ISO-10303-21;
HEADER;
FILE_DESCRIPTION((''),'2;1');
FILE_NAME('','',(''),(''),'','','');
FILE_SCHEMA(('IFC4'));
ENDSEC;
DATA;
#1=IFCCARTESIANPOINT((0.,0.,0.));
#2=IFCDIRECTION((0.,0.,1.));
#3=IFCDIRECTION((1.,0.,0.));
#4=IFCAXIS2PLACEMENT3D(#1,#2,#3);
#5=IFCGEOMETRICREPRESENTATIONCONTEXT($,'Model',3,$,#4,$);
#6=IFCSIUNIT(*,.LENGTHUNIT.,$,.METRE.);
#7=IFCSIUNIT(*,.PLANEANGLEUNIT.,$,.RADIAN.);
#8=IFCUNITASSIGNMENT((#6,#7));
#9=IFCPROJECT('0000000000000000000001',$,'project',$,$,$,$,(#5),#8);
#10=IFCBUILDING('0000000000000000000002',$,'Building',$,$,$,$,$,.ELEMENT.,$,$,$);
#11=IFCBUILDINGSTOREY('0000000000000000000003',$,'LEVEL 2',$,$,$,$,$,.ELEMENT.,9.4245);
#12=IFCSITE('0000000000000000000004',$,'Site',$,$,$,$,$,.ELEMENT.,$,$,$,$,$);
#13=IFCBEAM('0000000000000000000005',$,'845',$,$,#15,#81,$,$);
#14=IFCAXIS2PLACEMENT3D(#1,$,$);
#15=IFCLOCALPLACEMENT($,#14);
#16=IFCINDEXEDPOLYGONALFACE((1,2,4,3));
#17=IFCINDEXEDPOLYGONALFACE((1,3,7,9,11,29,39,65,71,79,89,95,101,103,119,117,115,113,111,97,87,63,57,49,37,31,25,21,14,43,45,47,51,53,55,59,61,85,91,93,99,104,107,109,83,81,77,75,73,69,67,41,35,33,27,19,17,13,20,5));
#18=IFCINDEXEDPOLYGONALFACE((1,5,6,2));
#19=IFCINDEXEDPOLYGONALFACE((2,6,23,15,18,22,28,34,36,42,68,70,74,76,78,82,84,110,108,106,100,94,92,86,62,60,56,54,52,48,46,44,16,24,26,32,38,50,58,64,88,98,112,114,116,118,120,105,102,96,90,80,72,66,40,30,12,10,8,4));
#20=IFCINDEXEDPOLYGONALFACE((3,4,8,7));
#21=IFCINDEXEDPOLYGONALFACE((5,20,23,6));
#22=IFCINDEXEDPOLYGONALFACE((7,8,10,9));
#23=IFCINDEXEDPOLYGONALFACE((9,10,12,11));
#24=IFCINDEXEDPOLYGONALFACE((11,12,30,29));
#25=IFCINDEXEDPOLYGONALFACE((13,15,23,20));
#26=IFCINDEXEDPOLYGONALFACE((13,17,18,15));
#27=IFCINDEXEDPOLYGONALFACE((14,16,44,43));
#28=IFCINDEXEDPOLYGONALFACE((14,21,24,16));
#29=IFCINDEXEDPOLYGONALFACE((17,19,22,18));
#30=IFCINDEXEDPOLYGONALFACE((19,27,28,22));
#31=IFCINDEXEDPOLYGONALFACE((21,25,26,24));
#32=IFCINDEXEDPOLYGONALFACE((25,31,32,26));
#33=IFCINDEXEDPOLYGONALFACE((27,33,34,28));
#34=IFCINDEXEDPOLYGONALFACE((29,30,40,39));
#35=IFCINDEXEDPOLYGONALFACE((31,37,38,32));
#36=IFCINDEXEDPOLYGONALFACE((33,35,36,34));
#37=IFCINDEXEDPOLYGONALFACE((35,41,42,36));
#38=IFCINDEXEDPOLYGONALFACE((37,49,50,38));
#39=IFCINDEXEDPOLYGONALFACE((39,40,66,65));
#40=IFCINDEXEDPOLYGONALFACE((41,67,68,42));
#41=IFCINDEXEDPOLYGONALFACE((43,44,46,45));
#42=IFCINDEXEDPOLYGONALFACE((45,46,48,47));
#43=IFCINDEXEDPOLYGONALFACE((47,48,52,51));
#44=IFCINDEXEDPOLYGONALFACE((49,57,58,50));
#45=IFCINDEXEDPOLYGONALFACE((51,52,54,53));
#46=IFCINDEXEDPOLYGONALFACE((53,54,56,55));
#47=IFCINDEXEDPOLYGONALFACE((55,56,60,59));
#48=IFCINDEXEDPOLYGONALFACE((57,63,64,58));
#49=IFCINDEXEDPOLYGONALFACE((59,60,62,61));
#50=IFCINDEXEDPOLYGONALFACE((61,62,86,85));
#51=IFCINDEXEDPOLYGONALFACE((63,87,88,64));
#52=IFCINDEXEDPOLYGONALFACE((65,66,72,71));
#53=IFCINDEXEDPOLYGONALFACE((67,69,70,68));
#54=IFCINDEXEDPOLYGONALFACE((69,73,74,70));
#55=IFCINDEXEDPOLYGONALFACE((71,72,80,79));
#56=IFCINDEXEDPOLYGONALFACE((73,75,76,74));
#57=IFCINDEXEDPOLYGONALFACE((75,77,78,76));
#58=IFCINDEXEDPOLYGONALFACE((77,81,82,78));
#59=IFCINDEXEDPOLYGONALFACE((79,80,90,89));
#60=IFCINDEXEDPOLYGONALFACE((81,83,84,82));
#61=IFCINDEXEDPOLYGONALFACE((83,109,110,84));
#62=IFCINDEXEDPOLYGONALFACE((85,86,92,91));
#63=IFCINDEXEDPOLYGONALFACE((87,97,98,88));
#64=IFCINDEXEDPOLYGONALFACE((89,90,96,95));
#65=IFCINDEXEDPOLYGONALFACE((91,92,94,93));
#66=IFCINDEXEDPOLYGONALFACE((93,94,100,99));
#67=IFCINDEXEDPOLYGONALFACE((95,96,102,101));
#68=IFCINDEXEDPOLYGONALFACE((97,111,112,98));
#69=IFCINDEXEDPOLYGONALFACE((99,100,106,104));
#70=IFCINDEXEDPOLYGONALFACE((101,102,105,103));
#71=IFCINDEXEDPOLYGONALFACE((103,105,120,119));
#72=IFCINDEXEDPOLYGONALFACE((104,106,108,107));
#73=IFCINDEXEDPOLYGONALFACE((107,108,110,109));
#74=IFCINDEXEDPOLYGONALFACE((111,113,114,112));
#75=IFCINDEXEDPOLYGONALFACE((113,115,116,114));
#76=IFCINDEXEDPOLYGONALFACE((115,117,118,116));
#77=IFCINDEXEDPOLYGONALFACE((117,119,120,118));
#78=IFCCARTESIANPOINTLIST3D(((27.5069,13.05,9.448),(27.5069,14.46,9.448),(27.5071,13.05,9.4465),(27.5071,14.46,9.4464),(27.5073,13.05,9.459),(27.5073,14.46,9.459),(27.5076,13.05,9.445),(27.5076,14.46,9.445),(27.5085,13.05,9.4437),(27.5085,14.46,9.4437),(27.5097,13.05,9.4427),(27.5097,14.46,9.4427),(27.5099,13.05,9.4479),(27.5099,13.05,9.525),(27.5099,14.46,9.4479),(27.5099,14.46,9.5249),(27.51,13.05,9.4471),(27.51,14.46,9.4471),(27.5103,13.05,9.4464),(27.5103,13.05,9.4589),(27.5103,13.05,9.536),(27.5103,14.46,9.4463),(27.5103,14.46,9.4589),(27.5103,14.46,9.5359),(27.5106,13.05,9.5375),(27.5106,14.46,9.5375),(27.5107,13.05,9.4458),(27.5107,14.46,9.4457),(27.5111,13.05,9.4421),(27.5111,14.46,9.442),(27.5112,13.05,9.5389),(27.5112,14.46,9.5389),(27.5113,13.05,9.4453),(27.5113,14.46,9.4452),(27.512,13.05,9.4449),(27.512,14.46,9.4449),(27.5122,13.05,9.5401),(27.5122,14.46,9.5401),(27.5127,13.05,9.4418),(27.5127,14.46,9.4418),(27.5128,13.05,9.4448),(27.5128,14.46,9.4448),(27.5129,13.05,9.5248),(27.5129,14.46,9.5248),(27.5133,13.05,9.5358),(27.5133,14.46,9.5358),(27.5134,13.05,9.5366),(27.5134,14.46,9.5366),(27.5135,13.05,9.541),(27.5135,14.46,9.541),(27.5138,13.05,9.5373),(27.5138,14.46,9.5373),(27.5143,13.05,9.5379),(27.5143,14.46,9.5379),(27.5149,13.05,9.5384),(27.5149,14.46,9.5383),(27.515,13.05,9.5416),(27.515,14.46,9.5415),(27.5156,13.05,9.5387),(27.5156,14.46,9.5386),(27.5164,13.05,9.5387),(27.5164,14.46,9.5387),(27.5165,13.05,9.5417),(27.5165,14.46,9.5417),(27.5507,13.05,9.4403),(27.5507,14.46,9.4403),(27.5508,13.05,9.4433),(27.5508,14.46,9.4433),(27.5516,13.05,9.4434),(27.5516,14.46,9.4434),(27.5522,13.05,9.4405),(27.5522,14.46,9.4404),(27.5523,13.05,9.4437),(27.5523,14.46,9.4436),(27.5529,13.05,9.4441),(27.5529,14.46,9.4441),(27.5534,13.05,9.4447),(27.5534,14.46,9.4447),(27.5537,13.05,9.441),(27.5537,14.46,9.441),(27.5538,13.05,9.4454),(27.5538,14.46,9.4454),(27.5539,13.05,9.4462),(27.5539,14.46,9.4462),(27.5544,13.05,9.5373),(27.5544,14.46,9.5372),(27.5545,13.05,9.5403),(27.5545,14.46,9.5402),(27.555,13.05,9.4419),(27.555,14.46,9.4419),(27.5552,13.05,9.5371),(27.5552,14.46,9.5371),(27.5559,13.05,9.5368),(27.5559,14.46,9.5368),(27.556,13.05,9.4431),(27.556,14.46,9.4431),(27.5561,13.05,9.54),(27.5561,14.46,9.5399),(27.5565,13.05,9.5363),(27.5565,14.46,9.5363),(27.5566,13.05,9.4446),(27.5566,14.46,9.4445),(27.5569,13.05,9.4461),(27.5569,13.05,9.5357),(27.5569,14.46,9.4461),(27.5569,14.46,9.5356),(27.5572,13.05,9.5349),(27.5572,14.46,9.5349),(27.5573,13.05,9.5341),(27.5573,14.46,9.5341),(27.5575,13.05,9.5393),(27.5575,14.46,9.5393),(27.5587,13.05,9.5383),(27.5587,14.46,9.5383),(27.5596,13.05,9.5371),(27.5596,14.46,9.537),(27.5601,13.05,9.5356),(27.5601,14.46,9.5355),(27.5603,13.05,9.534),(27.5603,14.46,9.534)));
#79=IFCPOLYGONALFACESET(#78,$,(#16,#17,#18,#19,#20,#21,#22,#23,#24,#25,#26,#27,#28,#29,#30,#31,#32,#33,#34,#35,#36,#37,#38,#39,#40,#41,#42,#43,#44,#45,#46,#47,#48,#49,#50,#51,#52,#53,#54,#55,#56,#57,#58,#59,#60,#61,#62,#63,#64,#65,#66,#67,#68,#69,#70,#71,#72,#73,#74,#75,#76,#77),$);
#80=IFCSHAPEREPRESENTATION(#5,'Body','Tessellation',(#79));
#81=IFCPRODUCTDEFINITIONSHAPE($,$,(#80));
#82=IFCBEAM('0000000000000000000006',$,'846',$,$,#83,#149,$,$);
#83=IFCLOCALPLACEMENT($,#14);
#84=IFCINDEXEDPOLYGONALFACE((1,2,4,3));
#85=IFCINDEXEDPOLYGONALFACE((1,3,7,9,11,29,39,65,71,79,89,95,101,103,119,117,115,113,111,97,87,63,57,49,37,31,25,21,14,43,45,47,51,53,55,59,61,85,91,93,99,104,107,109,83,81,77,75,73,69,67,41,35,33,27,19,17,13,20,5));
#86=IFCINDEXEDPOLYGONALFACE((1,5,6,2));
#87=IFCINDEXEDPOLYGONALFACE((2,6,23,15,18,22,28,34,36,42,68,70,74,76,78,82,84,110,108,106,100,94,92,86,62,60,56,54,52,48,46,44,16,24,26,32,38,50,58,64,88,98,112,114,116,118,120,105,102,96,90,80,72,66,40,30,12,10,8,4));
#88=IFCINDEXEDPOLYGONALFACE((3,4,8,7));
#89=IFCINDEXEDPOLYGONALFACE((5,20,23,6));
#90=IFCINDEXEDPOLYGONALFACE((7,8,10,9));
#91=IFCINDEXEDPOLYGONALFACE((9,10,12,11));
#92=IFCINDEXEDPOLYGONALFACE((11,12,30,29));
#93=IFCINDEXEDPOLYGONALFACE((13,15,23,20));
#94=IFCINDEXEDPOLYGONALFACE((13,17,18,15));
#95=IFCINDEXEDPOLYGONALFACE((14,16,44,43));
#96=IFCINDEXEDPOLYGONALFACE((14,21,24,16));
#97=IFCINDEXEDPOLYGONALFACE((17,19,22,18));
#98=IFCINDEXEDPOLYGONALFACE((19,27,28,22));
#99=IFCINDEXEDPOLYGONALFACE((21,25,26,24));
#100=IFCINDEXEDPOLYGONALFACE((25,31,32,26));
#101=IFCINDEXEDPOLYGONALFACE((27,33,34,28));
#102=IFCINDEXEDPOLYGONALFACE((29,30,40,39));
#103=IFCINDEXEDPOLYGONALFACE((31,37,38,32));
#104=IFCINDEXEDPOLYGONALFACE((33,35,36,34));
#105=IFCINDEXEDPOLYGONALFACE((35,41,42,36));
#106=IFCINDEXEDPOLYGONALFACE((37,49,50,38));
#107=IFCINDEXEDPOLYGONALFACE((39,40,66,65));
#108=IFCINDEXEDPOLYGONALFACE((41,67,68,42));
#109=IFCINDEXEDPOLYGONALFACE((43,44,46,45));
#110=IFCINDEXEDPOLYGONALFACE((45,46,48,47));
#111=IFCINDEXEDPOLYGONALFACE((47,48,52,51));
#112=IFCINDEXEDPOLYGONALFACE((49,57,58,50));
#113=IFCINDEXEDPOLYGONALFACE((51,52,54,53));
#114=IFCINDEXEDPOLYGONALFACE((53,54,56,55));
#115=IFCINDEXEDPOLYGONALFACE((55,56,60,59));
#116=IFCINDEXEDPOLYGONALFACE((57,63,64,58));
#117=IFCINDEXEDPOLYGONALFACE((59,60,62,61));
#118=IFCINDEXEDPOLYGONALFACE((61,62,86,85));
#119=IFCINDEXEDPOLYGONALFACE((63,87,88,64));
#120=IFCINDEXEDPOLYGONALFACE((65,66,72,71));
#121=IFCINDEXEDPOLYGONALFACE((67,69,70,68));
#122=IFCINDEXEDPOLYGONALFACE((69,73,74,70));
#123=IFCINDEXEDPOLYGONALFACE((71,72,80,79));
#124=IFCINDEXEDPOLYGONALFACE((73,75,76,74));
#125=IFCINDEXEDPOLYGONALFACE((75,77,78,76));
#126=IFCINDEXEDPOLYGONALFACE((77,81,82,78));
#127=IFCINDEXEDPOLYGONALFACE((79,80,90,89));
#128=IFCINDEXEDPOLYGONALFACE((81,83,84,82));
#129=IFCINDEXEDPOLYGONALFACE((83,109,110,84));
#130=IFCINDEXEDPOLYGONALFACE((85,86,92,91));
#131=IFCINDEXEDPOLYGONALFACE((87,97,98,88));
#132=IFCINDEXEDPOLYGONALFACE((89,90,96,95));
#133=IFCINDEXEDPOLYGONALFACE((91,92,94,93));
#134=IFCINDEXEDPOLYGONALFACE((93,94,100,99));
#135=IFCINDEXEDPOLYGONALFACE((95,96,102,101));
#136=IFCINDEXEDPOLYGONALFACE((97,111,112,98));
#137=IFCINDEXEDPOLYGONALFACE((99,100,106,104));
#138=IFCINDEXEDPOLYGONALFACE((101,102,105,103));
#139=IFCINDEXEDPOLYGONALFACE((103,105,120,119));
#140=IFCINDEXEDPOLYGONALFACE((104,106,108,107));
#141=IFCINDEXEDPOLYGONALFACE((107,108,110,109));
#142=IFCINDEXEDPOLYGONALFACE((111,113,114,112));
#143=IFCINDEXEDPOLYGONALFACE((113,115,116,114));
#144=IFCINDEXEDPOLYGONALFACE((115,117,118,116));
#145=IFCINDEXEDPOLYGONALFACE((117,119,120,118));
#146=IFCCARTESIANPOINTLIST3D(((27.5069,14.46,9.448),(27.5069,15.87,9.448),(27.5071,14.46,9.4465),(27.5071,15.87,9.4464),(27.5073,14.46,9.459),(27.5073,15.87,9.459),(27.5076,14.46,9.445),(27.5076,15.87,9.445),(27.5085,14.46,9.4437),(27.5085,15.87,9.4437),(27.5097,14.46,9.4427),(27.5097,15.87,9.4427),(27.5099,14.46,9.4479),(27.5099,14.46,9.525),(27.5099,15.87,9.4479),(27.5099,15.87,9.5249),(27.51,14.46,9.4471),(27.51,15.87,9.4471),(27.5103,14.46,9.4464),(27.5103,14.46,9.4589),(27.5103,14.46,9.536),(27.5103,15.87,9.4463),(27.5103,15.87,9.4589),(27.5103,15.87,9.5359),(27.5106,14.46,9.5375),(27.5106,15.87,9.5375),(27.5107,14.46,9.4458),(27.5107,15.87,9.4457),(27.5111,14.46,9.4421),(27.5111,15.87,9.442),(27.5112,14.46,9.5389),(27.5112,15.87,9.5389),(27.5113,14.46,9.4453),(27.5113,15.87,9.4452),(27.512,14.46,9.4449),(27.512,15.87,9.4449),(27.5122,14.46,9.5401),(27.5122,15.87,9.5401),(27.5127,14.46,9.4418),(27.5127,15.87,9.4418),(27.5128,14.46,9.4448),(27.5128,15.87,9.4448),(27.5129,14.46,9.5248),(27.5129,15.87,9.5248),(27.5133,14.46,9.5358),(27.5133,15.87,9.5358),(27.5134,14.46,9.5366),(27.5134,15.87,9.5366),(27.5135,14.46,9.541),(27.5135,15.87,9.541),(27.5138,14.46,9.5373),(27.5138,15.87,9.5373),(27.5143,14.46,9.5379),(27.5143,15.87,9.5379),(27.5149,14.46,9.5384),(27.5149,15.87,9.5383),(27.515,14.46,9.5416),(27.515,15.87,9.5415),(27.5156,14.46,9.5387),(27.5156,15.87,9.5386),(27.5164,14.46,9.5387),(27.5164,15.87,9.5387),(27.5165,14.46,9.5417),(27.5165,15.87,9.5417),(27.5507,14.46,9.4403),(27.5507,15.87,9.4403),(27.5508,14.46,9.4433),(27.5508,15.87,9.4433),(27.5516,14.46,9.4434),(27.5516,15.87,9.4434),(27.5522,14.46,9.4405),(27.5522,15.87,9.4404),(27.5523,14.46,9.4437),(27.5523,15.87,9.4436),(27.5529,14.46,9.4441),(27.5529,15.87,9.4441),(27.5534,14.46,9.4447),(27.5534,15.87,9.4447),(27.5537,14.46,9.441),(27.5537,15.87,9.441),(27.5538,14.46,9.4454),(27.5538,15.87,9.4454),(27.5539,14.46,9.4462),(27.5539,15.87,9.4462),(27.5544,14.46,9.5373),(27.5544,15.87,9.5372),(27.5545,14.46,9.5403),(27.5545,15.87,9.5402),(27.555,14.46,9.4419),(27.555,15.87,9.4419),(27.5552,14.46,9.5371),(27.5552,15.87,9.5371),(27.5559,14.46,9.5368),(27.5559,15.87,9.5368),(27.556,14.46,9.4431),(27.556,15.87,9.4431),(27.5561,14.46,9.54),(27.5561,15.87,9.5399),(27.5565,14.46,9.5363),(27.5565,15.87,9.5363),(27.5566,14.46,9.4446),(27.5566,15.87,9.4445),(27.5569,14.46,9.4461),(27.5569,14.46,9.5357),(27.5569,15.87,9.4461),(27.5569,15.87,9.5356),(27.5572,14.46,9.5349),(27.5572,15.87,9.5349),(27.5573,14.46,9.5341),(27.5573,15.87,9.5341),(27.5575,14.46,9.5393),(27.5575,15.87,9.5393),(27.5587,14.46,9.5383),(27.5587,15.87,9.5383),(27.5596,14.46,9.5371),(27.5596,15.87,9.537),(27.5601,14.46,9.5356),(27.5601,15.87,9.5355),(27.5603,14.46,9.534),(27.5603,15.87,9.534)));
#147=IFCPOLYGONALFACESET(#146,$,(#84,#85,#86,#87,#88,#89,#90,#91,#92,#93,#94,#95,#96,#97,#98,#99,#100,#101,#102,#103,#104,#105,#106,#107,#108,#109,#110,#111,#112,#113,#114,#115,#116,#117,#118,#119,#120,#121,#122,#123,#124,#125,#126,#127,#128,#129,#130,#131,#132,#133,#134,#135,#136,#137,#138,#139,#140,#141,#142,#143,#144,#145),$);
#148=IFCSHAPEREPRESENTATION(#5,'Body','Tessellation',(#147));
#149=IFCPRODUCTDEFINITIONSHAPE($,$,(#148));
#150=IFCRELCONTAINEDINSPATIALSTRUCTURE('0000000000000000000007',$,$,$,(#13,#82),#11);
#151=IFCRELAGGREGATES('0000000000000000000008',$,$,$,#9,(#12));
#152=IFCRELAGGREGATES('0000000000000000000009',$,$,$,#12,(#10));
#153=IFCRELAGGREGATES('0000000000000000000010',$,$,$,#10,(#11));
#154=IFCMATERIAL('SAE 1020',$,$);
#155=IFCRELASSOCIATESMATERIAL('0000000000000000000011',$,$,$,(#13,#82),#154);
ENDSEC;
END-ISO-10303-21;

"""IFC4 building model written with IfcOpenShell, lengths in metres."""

from ifc_helpers import new_model, si_unit, frame, origin_with_axes, origin_2d_with_axis, place, context, project, spatial, c_section, extrude, material, material_profile, profile_set, profile_usage, element, save


model = new_model("IFC4")

# Units and contexts
model_context = context("Model", 3, world=origin_with_axes())
ifc_project = project(units=[si_unit("LENGTHUNIT", "METRE"), si_unit("PLANEANGLEUNIT", "RADIAN")], contexts=[model_context])

# Site, building, storey
site = spatial("IfcSite", under=ifc_project, Name="Site", CompositionType="ELEMENT")
building = spatial("IfcBuilding", under=site, Name="Building", CompositionType="ELEMENT")
storey = spatial("IfcBuildingStorey", under=building, Name="LEVEL 2", CompositionType="ELEMENT", Elevation=9.4245)

# Beams
ifc_material = material(Name="SAE 1020")
ifc_material_profile_1 = material_profile(ifc_material, c_section(Depth=0.1, Width=0.05, WallThickness=0.003, Girth=0.017, InternalFilletRadius=0.003, at=origin_2d_with_axis()))
ifc_profile_set_1 = profile_set([ifc_material_profile_1])
ifc_profile_usage_1 = profile_usage(ifc_profile_set_1, cardinal=10)
beam_1_placement = place(None, frame((27.5336, 13.05, 9.491), z_axis=(0.0, 1.0, -0.00003), x_axis=(-0.999256, 0.000001, 0.038562)))
element("IfcBeam", 1, at=beam_1_placement, inside=storey, material=ifc_profile_usage_1, Name="845", context=model_context, shape_type="SweptSolid", body=[
    extrude(c_section(Depth=0.1, Width=0.05, WallThickness=0.003, Girth=0.017, InternalFilletRadius=0.003, at=origin_2d_with_axis()), origin_with_axes(), (0.0, 0.0, 1.0), 1.41),
])
ifc_material_profile_2 = material_profile(ifc_material, c_section(Depth=0.1, Width=0.05, WallThickness=0.003, Girth=0.017, InternalFilletRadius=0.003, at=origin_2d_with_axis()))
ifc_profile_set_2 = profile_set([ifc_material_profile_2])
ifc_profile_usage_2 = profile_usage(ifc_profile_set_2, cardinal=10)
beam_2_placement = place(None, frame((27.5336, 14.46, 9.491), z_axis=(0.0, 1.0, -0.00003), x_axis=(-0.999256, 0.000001, 0.038562)))
element("IfcBeam", 2, at=beam_2_placement, inside=storey, material=ifc_profile_usage_2, Name="846", context=model_context, shape_type="SweptSolid", body=[
    extrude(c_section(Depth=0.1, Width=0.05, WallThickness=0.003, Girth=0.017, InternalFilletRadius=0.003, at=origin_2d_with_axis()), origin_with_axes(), (0.0, 0.0, 1.0), 1.41),
])

save(model, "model.ifc")
